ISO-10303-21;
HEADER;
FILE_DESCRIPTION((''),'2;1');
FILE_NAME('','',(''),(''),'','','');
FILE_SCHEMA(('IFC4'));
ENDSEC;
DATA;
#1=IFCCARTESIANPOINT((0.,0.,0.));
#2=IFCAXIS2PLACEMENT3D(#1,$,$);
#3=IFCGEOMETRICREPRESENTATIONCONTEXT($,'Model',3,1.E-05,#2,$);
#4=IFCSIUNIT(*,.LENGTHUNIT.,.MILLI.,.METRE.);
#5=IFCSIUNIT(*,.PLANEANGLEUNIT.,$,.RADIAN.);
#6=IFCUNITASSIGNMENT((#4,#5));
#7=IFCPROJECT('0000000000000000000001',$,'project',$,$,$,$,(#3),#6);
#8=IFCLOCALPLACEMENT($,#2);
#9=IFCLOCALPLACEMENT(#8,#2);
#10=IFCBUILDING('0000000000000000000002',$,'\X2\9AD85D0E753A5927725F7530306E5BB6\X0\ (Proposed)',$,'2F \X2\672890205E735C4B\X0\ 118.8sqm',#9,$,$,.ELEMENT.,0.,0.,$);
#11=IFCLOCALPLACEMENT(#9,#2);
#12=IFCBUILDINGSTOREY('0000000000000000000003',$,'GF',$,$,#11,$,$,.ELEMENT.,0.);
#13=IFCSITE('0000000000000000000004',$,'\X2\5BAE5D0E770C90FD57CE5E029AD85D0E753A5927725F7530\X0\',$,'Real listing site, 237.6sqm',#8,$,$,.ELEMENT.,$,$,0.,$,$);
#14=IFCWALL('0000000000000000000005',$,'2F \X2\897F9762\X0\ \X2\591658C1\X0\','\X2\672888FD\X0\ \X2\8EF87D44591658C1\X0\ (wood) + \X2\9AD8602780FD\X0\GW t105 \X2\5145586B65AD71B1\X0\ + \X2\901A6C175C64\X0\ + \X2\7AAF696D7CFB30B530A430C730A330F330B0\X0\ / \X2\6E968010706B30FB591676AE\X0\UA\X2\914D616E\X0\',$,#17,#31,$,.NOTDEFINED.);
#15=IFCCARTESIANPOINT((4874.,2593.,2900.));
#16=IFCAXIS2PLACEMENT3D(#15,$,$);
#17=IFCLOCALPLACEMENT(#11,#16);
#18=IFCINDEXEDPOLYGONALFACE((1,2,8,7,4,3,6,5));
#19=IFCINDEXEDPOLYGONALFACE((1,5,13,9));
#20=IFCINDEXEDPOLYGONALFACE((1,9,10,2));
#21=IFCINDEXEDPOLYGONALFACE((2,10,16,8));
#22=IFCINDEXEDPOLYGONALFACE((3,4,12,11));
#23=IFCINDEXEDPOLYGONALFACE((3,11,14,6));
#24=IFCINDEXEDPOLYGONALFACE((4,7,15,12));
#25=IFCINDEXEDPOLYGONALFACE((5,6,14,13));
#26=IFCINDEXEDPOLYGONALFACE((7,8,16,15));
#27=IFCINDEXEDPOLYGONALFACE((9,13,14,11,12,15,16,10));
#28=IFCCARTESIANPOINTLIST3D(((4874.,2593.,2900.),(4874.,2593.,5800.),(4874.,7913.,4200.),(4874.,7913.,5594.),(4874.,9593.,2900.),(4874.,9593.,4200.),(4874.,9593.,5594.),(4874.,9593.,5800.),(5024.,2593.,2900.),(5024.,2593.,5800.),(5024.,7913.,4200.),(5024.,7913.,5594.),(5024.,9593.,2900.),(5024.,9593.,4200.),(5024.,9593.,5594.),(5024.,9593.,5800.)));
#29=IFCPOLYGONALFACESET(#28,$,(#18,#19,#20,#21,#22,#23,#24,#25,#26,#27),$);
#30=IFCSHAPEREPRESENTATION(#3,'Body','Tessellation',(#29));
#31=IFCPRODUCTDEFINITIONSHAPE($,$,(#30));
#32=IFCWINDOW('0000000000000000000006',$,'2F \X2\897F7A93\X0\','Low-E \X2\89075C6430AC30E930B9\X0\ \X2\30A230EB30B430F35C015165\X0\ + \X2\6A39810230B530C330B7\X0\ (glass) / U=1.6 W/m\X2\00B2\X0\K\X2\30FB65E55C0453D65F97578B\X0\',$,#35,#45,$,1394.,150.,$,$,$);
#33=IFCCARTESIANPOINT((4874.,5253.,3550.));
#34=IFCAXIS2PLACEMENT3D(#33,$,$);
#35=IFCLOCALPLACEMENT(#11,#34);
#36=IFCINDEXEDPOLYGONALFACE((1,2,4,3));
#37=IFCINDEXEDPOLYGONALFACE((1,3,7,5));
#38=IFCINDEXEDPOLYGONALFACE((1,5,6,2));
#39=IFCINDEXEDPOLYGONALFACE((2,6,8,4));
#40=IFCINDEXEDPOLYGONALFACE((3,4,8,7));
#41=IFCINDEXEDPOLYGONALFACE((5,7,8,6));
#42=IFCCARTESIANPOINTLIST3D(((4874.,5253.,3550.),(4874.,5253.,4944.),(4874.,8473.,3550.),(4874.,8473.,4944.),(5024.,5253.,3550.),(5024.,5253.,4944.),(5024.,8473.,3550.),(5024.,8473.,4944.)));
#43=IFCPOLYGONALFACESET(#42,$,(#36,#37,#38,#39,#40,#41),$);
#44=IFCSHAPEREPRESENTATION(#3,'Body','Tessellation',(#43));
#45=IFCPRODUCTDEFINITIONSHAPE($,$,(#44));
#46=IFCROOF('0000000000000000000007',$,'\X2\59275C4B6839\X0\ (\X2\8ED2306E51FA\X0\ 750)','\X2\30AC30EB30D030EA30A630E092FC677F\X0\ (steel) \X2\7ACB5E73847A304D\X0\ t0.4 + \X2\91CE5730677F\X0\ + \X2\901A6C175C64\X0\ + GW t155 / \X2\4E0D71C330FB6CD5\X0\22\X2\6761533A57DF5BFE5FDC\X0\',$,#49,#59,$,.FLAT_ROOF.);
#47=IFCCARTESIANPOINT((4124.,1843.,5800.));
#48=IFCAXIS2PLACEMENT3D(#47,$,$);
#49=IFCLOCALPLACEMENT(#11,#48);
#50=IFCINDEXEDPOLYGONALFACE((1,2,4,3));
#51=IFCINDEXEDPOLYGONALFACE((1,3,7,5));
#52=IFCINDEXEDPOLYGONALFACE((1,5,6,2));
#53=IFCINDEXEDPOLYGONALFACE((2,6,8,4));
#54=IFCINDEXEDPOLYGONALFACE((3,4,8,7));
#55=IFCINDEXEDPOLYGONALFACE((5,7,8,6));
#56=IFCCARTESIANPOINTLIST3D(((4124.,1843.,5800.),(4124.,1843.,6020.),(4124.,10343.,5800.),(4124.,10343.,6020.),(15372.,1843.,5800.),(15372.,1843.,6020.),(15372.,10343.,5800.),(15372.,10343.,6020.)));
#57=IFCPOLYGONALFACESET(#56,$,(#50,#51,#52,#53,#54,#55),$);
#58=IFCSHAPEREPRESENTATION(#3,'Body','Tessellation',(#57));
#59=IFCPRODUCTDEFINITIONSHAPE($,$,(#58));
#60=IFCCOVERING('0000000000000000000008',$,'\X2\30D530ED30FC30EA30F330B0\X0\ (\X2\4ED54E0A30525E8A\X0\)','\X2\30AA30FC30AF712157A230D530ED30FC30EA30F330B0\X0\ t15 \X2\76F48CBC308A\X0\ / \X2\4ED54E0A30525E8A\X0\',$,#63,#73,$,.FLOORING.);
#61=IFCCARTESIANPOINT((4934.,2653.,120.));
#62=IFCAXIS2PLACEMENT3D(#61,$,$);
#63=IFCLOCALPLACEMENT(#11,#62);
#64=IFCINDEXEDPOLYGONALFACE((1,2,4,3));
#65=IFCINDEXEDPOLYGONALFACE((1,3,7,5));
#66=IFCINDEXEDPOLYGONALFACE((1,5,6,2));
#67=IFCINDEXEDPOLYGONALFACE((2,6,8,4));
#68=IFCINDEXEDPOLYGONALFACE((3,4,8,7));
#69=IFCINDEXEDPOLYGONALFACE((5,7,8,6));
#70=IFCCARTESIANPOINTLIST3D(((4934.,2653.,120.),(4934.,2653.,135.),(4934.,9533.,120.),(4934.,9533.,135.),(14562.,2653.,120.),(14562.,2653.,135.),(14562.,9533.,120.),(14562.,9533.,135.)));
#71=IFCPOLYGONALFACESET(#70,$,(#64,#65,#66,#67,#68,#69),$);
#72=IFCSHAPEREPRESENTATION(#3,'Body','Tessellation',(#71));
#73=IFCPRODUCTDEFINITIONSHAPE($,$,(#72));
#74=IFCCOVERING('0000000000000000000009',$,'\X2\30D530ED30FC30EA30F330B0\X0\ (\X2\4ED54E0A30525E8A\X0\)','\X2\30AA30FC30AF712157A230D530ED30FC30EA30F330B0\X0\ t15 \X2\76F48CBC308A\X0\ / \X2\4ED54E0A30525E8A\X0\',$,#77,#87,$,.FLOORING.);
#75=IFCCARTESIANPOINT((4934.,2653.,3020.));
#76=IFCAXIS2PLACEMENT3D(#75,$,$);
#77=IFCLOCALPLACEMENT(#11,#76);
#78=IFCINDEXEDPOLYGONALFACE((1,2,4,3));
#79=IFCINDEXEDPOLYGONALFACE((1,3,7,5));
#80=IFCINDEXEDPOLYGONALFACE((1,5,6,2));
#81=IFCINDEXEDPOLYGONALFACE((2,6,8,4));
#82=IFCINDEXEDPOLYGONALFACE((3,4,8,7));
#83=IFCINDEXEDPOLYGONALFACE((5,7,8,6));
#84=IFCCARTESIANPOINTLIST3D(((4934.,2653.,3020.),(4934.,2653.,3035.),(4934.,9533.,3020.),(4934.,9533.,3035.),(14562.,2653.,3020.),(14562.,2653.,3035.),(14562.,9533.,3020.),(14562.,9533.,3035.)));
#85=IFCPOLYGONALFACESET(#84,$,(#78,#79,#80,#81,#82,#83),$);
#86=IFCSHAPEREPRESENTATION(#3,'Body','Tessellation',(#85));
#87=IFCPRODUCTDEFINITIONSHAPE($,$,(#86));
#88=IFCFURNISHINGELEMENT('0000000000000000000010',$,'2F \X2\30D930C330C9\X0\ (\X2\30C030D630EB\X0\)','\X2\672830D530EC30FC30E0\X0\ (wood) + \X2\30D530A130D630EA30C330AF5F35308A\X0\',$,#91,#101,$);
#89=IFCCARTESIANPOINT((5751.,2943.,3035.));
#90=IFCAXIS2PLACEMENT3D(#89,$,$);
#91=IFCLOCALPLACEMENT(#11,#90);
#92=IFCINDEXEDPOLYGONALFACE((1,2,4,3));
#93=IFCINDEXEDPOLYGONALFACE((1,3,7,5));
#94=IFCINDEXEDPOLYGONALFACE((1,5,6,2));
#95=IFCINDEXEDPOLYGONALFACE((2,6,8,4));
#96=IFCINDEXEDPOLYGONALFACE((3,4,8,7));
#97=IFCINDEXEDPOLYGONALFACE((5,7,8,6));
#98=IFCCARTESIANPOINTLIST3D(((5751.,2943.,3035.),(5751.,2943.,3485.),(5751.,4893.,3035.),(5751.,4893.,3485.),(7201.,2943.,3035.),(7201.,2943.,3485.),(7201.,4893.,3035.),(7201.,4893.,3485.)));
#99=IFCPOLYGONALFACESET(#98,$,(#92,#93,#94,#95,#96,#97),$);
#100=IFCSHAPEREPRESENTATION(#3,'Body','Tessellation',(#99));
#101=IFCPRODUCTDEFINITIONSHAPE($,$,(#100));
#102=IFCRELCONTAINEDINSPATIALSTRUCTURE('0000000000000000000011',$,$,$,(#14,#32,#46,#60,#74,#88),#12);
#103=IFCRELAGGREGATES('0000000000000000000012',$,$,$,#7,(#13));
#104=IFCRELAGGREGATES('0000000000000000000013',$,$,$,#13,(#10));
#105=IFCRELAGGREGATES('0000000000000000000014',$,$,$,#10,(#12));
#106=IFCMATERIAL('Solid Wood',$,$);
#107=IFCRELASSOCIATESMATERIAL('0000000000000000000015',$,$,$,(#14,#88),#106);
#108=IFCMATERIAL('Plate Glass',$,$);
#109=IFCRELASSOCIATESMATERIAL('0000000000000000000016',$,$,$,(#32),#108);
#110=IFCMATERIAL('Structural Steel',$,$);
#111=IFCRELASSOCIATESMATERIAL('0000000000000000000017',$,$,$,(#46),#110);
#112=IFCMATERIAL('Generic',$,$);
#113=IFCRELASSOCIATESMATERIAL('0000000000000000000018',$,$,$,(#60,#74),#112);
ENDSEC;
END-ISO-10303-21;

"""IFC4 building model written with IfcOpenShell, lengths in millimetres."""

from ifc_helpers import new_model, si_unit, frame, frame_2d, origin, place, context, project, spatial, rectangle, extrude, material, element, fill, save


model = new_model("IFC4")

# Units and contexts
model_context = context("Model", 3, precision=1e-05, world=origin())
ifc_project = project(units=[si_unit("LENGTHUNIT", "METRE", prefix="MILLI"), si_unit("PLANEANGLEUNIT", "RADIAN")], contexts=[model_context])

# Site, building, storey
site_placement = place(None, origin())
site = spatial("IfcSite", under=ifc_project, at=site_placement, Name="宮崎県都城市高崎町大牟田", ObjectType="Real listing site, 237.6sqm", CompositionType="ELEMENT", RefElevation=0.0)
building_placement = place(site_placement, origin())
building = spatial("IfcBuilding", under=site, at=building_placement, Name="高崎町大牟田の家 (Proposed)", ObjectType="2F 木造平屋 118.8sqm", CompositionType="ELEMENT", ElevationOfRefHeight=0.0, ElevationOfTerrain=0.0)
storey_placement = place(building_placement, origin())
storey = spatial("IfcBuildingStorey", under=building, at=storey_placement, Name="GF", CompositionType="ELEMENT", Elevation=0.0)

# Shared definitions
ifc_material_1 = material(Name="Solid Wood")

# Shared definitions
ifc_material_2 = material(Name="Plate Glass")

# Wall, opening, window
wall_1_placement = place(storey_placement, frame((4874.0, 2593.0, 2900.0)))
wall_1 = element("IfcWall", 1, at=wall_1_placement, inside=storey, material=ifc_material_1, Name="2F 西面 外壁", Description="木製 軸組外壁 (wood) + 高性能GW t105 充填断熱 + 通気層 + 窯業系サイディング / 準耐火・外皮UA配慮", PredefinedType="NOTDEFINED", context=model_context, shape_type="SweptSolid", body=[
    extrude(rectangle(XDim=150.0, YDim=7000.0, at=frame_2d((75.0, 3500.0))), frame((4874.0, 2593.0, 2900.0)), (0.0, 0.0, 1.0), 2900.0),
])
opening_1_placement = place(storey_placement, frame((4874.0, 5253.0, 3550.0)))
opening_1 = element("IfcOpeningElement", 2, at=opening_1_placement, cuts=wall_1, PredefinedType="NOTDEFINED", context=model_context, shape_type="SweptSolid", body=[
    extrude(rectangle(XDim=150.0, YDim=3220.0, at=frame_2d((75.0, 1610.0))), frame((4874.0, 5253.0, 3550.0)), (0.0, 0.0, 1.0), 1394.0),
])
window_1_placement = place(storey_placement, frame((4874.0, 5253.0, 3550.0)))
window_1 = element("IfcWindow", 3, at=window_1_placement, inside=storey, material=ifc_material_2, Name="2F 西窓", Description="Low-E 複層ガラス アルゴン封入 + 樹脂サッシ (glass) / U=1.6 W/m²K・日射取得型", OverallHeight=1394.0, OverallWidth=150.0, context=model_context, shape_type="SweptSolid", body=[
    extrude(rectangle(XDim=150.0, YDim=3220.0, at=frame_2d((75.0, 1610.0))), frame((4874.0, 5253.0, 3550.0)), (0.0, 0.0, 1.0), 1394.0),
])
fill(opening_1, window_1)

# Roof
ifc_material_3 = material(Name="Structural Steel")
roof_placement = place(storey_placement, frame((4124.0, 1843.0, 5800.0)))
element("IfcRoof", 4, at=roof_placement, inside=storey, material=ifc_material_3, Name="大屋根 (軒の出 750)", Description="ガルバリウム鋼板 (steel) 立平葺き t0.4 + 野地板 + 通気層 + GW t155 / 不燃・法22条区域対応", PredefinedType="FLAT_ROOF", context=model_context, shape_type="SweptSolid", body=[
    extrude(rectangle(XDim=11248.0, YDim=8500.0, at=frame_2d((5624.0, 4250.0))), frame((4124.0, 1843.0, 5800.0)), (0.0, 0.0, 1.0), 220.0),
])

# Coverings
ifc_material_4 = material(Name="Generic")
covering_1_placement = place(storey_placement, frame((4934.0, 2653.0, 120.0)))
element("IfcCovering", 5, at=covering_1_placement, inside=storey, material=ifc_material_4, Name="フローリング (仕上げ床)", Description="オーク無垢フローリング t15 直貼り / 仕上げ床", PredefinedType="FLOORING", context=model_context, shape_type="SweptSolid", body=[
    extrude(rectangle(XDim=9628.0, YDim=6880.0, at=frame_2d((4814.0, 3440.0))), frame((4934.0, 2653.0, 120.0)), (0.0, 0.0, 1.0), 15.0),
])
covering_2_placement = place(storey_placement, frame((4934.0, 2653.0, 3020.0)))
element("IfcCovering", 6, at=covering_2_placement, inside=storey, material=ifc_material_4, Name="フローリング (仕上げ床)", Description="オーク無垢フローリング t15 直貼り / 仕上げ床", PredefinedType="FLOORING", context=model_context, shape_type="SweptSolid", body=[
    extrude(rectangle(XDim=9628.0, YDim=6880.0, at=frame_2d((4814.0, 3440.0))), frame((4934.0, 2653.0, 3020.0)), (0.0, 0.0, 1.0), 15.0),
])

# Furnishing element
furnishing_placement = place(storey_placement, frame((5751.0, 2943.0, 3035.0)))
element("IfcFurnishingElement", 7, at=furnishing_placement, inside=storey, material=ifc_material_1, Name="2F ベッド (ダブル)", Description="木フレーム (wood) + ファブリック張り", context=model_context, shape_type="SweptSolid", body=[
    extrude(rectangle(XDim=1450.0, YDim=1950.0, at=frame_2d((725.0, 975.0))), frame((5751.0, 2943.0, 3035.0)), (0.0, 0.0, 1.0), 450.0),
])

save(model, "model.ifc")
